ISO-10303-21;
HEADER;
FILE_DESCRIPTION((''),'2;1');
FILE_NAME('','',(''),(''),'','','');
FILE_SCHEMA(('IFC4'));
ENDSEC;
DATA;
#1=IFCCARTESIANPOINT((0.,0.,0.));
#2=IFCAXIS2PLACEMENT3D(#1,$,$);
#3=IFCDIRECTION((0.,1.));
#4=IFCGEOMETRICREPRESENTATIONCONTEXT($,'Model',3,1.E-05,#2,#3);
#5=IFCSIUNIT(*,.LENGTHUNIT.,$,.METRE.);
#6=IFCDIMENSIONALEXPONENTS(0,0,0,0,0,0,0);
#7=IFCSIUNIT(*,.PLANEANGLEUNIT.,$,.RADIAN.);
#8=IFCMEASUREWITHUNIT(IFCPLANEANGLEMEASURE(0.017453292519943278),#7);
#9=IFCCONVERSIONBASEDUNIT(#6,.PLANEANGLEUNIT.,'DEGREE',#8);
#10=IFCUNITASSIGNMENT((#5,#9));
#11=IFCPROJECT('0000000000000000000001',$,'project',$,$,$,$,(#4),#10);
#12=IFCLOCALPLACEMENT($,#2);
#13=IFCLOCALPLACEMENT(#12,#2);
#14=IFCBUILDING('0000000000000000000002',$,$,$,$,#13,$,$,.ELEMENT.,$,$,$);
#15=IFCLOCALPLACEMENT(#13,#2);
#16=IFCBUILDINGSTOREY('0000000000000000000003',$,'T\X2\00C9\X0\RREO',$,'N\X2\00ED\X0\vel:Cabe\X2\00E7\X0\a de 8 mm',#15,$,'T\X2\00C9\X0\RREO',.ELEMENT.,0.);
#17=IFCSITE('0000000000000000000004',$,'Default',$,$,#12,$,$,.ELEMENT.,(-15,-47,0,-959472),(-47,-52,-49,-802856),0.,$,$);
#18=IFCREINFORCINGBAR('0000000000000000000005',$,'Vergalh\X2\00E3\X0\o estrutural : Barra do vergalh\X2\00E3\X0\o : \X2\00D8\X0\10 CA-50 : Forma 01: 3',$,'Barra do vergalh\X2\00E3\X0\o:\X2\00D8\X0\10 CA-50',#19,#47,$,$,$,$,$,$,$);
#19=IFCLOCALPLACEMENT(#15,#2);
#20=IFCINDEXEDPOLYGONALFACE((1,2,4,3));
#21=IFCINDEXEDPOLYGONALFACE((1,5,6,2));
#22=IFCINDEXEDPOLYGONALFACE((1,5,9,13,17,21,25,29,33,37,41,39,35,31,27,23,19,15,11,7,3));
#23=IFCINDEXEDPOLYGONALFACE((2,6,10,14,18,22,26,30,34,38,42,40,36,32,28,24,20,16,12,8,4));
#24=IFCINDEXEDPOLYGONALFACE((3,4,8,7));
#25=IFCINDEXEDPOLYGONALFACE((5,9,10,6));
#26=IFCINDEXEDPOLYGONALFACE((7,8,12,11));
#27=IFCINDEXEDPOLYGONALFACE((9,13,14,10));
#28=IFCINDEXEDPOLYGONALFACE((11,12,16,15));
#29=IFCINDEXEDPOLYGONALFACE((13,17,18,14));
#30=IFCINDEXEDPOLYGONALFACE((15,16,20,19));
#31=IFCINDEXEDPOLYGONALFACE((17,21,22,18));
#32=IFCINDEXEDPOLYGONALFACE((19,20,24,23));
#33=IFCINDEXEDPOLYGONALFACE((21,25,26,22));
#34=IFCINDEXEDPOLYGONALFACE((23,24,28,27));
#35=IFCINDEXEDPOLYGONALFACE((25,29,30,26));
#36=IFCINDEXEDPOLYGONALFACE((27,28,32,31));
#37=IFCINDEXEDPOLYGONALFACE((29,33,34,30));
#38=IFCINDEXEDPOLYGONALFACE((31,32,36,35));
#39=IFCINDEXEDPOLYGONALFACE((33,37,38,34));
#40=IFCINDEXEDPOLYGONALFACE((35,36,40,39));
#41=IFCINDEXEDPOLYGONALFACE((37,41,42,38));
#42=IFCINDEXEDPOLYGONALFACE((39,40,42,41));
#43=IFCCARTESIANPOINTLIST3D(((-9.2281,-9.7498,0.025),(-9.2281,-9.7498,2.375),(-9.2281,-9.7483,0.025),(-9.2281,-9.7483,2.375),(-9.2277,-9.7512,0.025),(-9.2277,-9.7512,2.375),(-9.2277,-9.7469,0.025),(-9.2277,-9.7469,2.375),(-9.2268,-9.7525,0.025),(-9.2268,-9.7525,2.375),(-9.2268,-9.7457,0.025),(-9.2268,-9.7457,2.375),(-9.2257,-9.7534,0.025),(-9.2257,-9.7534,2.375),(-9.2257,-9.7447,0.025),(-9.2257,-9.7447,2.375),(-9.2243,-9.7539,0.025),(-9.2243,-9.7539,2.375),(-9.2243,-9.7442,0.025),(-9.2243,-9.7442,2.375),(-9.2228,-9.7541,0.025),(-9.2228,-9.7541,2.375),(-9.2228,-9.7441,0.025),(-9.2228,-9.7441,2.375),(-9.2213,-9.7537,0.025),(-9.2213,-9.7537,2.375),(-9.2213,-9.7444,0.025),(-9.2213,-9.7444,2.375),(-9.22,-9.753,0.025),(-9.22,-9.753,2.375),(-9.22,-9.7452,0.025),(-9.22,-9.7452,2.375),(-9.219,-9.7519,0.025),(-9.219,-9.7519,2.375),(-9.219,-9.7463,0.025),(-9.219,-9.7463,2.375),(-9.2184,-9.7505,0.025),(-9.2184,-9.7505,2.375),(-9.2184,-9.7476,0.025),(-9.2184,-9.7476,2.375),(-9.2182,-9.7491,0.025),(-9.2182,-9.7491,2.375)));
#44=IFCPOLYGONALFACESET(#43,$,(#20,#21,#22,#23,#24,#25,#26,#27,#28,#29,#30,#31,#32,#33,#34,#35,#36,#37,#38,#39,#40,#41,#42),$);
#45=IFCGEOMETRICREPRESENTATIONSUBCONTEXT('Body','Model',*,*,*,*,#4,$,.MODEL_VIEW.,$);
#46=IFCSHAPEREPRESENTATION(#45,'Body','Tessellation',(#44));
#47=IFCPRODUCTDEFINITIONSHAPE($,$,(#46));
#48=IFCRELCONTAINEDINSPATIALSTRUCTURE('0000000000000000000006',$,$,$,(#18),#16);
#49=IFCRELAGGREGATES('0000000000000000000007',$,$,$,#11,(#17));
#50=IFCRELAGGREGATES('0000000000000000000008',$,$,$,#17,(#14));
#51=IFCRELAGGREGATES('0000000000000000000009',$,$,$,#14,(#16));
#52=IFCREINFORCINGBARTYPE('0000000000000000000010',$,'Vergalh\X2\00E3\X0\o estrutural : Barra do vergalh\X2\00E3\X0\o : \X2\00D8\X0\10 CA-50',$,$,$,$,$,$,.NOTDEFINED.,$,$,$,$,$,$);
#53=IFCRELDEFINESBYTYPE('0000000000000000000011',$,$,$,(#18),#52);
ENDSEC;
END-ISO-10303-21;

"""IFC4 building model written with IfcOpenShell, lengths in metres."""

from ifc_helpers import new_model, entity, si_unit, converted_unit, direction, origin, place, context, subcontext, project, spatial, type_object, element, save


model = new_model("IFC4")

# Units and contexts
model_context = context("Model", 3, precision=1e-05, world=origin(), true_north=direction((0.0, 1.0)))
body_context = subcontext(model_context, "Body", "Model", "MODEL_VIEW")
ifc_project = project(units=[si_unit("LENGTHUNIT", "METRE"), converted_unit("PLANEANGLEUNIT", "DEGREE", entity("IfcPlaneAngleMeasure", 0.017453292519943278), si_unit("PLANEANGLEUNIT", "RADIAN"), dimensions=[0, 0, 0, 0, 0, 0, 0])], contexts=[model_context])

# Site, building, storey
site_placement = place(None, origin())
site = spatial("IfcSite", under=ifc_project, at=site_placement, Name="Default", CompositionType="ELEMENT", RefLatitude=(-15, -47, 0, -959472), RefLongitude=(-47, -52, -49, -802856), RefElevation=0.0)
building_placement = place(site_placement, origin())
building = spatial("IfcBuilding", under=site, at=building_placement, CompositionType="ELEMENT")
storey_placement = place(building_placement, origin())
storey = spatial("IfcBuildingStorey", under=building, at=storey_placement, Name="TÉRREO", ObjectType="Nível:Cabeça de 8 mm", LongName="TÉRREO", CompositionType="ELEMENT", Elevation=0.0)

# Reinforcing bar
reinforcing_bar_type_1 = type_object("IfcReinforcingBarType", Name="Vergalhão estrutural : Barra do vergalhão : Ø10 CA-50", PredefinedType="NOTDEFINED")
reinforcing_bar_1_placement = place(storey_placement, origin())
element("IfcReinforcingBar", 1, at=reinforcing_bar_1_placement, inside=storey, type_object=reinforcing_bar_type_1, Name="Vergalhão estrutural : Barra do vergalhão : Ø10 CA-50 : Forma 01: 3", ObjectType="Barra do vergalhão:Ø10 CA-50", context=body_context, shape_type="AdvancedSweptSolid", body=[
    entity("IfcSweptDiskSolid", entity("IfcIndexedPolyCurve", entity("IfcCartesianPointList3D", [[-9.2232, -9.7491, 0.025], [-9.2232, -9.7491, 2.375]]), None, False), 0.005, None, 0.0, 1.0),
])

save(model, "model.ifc")
